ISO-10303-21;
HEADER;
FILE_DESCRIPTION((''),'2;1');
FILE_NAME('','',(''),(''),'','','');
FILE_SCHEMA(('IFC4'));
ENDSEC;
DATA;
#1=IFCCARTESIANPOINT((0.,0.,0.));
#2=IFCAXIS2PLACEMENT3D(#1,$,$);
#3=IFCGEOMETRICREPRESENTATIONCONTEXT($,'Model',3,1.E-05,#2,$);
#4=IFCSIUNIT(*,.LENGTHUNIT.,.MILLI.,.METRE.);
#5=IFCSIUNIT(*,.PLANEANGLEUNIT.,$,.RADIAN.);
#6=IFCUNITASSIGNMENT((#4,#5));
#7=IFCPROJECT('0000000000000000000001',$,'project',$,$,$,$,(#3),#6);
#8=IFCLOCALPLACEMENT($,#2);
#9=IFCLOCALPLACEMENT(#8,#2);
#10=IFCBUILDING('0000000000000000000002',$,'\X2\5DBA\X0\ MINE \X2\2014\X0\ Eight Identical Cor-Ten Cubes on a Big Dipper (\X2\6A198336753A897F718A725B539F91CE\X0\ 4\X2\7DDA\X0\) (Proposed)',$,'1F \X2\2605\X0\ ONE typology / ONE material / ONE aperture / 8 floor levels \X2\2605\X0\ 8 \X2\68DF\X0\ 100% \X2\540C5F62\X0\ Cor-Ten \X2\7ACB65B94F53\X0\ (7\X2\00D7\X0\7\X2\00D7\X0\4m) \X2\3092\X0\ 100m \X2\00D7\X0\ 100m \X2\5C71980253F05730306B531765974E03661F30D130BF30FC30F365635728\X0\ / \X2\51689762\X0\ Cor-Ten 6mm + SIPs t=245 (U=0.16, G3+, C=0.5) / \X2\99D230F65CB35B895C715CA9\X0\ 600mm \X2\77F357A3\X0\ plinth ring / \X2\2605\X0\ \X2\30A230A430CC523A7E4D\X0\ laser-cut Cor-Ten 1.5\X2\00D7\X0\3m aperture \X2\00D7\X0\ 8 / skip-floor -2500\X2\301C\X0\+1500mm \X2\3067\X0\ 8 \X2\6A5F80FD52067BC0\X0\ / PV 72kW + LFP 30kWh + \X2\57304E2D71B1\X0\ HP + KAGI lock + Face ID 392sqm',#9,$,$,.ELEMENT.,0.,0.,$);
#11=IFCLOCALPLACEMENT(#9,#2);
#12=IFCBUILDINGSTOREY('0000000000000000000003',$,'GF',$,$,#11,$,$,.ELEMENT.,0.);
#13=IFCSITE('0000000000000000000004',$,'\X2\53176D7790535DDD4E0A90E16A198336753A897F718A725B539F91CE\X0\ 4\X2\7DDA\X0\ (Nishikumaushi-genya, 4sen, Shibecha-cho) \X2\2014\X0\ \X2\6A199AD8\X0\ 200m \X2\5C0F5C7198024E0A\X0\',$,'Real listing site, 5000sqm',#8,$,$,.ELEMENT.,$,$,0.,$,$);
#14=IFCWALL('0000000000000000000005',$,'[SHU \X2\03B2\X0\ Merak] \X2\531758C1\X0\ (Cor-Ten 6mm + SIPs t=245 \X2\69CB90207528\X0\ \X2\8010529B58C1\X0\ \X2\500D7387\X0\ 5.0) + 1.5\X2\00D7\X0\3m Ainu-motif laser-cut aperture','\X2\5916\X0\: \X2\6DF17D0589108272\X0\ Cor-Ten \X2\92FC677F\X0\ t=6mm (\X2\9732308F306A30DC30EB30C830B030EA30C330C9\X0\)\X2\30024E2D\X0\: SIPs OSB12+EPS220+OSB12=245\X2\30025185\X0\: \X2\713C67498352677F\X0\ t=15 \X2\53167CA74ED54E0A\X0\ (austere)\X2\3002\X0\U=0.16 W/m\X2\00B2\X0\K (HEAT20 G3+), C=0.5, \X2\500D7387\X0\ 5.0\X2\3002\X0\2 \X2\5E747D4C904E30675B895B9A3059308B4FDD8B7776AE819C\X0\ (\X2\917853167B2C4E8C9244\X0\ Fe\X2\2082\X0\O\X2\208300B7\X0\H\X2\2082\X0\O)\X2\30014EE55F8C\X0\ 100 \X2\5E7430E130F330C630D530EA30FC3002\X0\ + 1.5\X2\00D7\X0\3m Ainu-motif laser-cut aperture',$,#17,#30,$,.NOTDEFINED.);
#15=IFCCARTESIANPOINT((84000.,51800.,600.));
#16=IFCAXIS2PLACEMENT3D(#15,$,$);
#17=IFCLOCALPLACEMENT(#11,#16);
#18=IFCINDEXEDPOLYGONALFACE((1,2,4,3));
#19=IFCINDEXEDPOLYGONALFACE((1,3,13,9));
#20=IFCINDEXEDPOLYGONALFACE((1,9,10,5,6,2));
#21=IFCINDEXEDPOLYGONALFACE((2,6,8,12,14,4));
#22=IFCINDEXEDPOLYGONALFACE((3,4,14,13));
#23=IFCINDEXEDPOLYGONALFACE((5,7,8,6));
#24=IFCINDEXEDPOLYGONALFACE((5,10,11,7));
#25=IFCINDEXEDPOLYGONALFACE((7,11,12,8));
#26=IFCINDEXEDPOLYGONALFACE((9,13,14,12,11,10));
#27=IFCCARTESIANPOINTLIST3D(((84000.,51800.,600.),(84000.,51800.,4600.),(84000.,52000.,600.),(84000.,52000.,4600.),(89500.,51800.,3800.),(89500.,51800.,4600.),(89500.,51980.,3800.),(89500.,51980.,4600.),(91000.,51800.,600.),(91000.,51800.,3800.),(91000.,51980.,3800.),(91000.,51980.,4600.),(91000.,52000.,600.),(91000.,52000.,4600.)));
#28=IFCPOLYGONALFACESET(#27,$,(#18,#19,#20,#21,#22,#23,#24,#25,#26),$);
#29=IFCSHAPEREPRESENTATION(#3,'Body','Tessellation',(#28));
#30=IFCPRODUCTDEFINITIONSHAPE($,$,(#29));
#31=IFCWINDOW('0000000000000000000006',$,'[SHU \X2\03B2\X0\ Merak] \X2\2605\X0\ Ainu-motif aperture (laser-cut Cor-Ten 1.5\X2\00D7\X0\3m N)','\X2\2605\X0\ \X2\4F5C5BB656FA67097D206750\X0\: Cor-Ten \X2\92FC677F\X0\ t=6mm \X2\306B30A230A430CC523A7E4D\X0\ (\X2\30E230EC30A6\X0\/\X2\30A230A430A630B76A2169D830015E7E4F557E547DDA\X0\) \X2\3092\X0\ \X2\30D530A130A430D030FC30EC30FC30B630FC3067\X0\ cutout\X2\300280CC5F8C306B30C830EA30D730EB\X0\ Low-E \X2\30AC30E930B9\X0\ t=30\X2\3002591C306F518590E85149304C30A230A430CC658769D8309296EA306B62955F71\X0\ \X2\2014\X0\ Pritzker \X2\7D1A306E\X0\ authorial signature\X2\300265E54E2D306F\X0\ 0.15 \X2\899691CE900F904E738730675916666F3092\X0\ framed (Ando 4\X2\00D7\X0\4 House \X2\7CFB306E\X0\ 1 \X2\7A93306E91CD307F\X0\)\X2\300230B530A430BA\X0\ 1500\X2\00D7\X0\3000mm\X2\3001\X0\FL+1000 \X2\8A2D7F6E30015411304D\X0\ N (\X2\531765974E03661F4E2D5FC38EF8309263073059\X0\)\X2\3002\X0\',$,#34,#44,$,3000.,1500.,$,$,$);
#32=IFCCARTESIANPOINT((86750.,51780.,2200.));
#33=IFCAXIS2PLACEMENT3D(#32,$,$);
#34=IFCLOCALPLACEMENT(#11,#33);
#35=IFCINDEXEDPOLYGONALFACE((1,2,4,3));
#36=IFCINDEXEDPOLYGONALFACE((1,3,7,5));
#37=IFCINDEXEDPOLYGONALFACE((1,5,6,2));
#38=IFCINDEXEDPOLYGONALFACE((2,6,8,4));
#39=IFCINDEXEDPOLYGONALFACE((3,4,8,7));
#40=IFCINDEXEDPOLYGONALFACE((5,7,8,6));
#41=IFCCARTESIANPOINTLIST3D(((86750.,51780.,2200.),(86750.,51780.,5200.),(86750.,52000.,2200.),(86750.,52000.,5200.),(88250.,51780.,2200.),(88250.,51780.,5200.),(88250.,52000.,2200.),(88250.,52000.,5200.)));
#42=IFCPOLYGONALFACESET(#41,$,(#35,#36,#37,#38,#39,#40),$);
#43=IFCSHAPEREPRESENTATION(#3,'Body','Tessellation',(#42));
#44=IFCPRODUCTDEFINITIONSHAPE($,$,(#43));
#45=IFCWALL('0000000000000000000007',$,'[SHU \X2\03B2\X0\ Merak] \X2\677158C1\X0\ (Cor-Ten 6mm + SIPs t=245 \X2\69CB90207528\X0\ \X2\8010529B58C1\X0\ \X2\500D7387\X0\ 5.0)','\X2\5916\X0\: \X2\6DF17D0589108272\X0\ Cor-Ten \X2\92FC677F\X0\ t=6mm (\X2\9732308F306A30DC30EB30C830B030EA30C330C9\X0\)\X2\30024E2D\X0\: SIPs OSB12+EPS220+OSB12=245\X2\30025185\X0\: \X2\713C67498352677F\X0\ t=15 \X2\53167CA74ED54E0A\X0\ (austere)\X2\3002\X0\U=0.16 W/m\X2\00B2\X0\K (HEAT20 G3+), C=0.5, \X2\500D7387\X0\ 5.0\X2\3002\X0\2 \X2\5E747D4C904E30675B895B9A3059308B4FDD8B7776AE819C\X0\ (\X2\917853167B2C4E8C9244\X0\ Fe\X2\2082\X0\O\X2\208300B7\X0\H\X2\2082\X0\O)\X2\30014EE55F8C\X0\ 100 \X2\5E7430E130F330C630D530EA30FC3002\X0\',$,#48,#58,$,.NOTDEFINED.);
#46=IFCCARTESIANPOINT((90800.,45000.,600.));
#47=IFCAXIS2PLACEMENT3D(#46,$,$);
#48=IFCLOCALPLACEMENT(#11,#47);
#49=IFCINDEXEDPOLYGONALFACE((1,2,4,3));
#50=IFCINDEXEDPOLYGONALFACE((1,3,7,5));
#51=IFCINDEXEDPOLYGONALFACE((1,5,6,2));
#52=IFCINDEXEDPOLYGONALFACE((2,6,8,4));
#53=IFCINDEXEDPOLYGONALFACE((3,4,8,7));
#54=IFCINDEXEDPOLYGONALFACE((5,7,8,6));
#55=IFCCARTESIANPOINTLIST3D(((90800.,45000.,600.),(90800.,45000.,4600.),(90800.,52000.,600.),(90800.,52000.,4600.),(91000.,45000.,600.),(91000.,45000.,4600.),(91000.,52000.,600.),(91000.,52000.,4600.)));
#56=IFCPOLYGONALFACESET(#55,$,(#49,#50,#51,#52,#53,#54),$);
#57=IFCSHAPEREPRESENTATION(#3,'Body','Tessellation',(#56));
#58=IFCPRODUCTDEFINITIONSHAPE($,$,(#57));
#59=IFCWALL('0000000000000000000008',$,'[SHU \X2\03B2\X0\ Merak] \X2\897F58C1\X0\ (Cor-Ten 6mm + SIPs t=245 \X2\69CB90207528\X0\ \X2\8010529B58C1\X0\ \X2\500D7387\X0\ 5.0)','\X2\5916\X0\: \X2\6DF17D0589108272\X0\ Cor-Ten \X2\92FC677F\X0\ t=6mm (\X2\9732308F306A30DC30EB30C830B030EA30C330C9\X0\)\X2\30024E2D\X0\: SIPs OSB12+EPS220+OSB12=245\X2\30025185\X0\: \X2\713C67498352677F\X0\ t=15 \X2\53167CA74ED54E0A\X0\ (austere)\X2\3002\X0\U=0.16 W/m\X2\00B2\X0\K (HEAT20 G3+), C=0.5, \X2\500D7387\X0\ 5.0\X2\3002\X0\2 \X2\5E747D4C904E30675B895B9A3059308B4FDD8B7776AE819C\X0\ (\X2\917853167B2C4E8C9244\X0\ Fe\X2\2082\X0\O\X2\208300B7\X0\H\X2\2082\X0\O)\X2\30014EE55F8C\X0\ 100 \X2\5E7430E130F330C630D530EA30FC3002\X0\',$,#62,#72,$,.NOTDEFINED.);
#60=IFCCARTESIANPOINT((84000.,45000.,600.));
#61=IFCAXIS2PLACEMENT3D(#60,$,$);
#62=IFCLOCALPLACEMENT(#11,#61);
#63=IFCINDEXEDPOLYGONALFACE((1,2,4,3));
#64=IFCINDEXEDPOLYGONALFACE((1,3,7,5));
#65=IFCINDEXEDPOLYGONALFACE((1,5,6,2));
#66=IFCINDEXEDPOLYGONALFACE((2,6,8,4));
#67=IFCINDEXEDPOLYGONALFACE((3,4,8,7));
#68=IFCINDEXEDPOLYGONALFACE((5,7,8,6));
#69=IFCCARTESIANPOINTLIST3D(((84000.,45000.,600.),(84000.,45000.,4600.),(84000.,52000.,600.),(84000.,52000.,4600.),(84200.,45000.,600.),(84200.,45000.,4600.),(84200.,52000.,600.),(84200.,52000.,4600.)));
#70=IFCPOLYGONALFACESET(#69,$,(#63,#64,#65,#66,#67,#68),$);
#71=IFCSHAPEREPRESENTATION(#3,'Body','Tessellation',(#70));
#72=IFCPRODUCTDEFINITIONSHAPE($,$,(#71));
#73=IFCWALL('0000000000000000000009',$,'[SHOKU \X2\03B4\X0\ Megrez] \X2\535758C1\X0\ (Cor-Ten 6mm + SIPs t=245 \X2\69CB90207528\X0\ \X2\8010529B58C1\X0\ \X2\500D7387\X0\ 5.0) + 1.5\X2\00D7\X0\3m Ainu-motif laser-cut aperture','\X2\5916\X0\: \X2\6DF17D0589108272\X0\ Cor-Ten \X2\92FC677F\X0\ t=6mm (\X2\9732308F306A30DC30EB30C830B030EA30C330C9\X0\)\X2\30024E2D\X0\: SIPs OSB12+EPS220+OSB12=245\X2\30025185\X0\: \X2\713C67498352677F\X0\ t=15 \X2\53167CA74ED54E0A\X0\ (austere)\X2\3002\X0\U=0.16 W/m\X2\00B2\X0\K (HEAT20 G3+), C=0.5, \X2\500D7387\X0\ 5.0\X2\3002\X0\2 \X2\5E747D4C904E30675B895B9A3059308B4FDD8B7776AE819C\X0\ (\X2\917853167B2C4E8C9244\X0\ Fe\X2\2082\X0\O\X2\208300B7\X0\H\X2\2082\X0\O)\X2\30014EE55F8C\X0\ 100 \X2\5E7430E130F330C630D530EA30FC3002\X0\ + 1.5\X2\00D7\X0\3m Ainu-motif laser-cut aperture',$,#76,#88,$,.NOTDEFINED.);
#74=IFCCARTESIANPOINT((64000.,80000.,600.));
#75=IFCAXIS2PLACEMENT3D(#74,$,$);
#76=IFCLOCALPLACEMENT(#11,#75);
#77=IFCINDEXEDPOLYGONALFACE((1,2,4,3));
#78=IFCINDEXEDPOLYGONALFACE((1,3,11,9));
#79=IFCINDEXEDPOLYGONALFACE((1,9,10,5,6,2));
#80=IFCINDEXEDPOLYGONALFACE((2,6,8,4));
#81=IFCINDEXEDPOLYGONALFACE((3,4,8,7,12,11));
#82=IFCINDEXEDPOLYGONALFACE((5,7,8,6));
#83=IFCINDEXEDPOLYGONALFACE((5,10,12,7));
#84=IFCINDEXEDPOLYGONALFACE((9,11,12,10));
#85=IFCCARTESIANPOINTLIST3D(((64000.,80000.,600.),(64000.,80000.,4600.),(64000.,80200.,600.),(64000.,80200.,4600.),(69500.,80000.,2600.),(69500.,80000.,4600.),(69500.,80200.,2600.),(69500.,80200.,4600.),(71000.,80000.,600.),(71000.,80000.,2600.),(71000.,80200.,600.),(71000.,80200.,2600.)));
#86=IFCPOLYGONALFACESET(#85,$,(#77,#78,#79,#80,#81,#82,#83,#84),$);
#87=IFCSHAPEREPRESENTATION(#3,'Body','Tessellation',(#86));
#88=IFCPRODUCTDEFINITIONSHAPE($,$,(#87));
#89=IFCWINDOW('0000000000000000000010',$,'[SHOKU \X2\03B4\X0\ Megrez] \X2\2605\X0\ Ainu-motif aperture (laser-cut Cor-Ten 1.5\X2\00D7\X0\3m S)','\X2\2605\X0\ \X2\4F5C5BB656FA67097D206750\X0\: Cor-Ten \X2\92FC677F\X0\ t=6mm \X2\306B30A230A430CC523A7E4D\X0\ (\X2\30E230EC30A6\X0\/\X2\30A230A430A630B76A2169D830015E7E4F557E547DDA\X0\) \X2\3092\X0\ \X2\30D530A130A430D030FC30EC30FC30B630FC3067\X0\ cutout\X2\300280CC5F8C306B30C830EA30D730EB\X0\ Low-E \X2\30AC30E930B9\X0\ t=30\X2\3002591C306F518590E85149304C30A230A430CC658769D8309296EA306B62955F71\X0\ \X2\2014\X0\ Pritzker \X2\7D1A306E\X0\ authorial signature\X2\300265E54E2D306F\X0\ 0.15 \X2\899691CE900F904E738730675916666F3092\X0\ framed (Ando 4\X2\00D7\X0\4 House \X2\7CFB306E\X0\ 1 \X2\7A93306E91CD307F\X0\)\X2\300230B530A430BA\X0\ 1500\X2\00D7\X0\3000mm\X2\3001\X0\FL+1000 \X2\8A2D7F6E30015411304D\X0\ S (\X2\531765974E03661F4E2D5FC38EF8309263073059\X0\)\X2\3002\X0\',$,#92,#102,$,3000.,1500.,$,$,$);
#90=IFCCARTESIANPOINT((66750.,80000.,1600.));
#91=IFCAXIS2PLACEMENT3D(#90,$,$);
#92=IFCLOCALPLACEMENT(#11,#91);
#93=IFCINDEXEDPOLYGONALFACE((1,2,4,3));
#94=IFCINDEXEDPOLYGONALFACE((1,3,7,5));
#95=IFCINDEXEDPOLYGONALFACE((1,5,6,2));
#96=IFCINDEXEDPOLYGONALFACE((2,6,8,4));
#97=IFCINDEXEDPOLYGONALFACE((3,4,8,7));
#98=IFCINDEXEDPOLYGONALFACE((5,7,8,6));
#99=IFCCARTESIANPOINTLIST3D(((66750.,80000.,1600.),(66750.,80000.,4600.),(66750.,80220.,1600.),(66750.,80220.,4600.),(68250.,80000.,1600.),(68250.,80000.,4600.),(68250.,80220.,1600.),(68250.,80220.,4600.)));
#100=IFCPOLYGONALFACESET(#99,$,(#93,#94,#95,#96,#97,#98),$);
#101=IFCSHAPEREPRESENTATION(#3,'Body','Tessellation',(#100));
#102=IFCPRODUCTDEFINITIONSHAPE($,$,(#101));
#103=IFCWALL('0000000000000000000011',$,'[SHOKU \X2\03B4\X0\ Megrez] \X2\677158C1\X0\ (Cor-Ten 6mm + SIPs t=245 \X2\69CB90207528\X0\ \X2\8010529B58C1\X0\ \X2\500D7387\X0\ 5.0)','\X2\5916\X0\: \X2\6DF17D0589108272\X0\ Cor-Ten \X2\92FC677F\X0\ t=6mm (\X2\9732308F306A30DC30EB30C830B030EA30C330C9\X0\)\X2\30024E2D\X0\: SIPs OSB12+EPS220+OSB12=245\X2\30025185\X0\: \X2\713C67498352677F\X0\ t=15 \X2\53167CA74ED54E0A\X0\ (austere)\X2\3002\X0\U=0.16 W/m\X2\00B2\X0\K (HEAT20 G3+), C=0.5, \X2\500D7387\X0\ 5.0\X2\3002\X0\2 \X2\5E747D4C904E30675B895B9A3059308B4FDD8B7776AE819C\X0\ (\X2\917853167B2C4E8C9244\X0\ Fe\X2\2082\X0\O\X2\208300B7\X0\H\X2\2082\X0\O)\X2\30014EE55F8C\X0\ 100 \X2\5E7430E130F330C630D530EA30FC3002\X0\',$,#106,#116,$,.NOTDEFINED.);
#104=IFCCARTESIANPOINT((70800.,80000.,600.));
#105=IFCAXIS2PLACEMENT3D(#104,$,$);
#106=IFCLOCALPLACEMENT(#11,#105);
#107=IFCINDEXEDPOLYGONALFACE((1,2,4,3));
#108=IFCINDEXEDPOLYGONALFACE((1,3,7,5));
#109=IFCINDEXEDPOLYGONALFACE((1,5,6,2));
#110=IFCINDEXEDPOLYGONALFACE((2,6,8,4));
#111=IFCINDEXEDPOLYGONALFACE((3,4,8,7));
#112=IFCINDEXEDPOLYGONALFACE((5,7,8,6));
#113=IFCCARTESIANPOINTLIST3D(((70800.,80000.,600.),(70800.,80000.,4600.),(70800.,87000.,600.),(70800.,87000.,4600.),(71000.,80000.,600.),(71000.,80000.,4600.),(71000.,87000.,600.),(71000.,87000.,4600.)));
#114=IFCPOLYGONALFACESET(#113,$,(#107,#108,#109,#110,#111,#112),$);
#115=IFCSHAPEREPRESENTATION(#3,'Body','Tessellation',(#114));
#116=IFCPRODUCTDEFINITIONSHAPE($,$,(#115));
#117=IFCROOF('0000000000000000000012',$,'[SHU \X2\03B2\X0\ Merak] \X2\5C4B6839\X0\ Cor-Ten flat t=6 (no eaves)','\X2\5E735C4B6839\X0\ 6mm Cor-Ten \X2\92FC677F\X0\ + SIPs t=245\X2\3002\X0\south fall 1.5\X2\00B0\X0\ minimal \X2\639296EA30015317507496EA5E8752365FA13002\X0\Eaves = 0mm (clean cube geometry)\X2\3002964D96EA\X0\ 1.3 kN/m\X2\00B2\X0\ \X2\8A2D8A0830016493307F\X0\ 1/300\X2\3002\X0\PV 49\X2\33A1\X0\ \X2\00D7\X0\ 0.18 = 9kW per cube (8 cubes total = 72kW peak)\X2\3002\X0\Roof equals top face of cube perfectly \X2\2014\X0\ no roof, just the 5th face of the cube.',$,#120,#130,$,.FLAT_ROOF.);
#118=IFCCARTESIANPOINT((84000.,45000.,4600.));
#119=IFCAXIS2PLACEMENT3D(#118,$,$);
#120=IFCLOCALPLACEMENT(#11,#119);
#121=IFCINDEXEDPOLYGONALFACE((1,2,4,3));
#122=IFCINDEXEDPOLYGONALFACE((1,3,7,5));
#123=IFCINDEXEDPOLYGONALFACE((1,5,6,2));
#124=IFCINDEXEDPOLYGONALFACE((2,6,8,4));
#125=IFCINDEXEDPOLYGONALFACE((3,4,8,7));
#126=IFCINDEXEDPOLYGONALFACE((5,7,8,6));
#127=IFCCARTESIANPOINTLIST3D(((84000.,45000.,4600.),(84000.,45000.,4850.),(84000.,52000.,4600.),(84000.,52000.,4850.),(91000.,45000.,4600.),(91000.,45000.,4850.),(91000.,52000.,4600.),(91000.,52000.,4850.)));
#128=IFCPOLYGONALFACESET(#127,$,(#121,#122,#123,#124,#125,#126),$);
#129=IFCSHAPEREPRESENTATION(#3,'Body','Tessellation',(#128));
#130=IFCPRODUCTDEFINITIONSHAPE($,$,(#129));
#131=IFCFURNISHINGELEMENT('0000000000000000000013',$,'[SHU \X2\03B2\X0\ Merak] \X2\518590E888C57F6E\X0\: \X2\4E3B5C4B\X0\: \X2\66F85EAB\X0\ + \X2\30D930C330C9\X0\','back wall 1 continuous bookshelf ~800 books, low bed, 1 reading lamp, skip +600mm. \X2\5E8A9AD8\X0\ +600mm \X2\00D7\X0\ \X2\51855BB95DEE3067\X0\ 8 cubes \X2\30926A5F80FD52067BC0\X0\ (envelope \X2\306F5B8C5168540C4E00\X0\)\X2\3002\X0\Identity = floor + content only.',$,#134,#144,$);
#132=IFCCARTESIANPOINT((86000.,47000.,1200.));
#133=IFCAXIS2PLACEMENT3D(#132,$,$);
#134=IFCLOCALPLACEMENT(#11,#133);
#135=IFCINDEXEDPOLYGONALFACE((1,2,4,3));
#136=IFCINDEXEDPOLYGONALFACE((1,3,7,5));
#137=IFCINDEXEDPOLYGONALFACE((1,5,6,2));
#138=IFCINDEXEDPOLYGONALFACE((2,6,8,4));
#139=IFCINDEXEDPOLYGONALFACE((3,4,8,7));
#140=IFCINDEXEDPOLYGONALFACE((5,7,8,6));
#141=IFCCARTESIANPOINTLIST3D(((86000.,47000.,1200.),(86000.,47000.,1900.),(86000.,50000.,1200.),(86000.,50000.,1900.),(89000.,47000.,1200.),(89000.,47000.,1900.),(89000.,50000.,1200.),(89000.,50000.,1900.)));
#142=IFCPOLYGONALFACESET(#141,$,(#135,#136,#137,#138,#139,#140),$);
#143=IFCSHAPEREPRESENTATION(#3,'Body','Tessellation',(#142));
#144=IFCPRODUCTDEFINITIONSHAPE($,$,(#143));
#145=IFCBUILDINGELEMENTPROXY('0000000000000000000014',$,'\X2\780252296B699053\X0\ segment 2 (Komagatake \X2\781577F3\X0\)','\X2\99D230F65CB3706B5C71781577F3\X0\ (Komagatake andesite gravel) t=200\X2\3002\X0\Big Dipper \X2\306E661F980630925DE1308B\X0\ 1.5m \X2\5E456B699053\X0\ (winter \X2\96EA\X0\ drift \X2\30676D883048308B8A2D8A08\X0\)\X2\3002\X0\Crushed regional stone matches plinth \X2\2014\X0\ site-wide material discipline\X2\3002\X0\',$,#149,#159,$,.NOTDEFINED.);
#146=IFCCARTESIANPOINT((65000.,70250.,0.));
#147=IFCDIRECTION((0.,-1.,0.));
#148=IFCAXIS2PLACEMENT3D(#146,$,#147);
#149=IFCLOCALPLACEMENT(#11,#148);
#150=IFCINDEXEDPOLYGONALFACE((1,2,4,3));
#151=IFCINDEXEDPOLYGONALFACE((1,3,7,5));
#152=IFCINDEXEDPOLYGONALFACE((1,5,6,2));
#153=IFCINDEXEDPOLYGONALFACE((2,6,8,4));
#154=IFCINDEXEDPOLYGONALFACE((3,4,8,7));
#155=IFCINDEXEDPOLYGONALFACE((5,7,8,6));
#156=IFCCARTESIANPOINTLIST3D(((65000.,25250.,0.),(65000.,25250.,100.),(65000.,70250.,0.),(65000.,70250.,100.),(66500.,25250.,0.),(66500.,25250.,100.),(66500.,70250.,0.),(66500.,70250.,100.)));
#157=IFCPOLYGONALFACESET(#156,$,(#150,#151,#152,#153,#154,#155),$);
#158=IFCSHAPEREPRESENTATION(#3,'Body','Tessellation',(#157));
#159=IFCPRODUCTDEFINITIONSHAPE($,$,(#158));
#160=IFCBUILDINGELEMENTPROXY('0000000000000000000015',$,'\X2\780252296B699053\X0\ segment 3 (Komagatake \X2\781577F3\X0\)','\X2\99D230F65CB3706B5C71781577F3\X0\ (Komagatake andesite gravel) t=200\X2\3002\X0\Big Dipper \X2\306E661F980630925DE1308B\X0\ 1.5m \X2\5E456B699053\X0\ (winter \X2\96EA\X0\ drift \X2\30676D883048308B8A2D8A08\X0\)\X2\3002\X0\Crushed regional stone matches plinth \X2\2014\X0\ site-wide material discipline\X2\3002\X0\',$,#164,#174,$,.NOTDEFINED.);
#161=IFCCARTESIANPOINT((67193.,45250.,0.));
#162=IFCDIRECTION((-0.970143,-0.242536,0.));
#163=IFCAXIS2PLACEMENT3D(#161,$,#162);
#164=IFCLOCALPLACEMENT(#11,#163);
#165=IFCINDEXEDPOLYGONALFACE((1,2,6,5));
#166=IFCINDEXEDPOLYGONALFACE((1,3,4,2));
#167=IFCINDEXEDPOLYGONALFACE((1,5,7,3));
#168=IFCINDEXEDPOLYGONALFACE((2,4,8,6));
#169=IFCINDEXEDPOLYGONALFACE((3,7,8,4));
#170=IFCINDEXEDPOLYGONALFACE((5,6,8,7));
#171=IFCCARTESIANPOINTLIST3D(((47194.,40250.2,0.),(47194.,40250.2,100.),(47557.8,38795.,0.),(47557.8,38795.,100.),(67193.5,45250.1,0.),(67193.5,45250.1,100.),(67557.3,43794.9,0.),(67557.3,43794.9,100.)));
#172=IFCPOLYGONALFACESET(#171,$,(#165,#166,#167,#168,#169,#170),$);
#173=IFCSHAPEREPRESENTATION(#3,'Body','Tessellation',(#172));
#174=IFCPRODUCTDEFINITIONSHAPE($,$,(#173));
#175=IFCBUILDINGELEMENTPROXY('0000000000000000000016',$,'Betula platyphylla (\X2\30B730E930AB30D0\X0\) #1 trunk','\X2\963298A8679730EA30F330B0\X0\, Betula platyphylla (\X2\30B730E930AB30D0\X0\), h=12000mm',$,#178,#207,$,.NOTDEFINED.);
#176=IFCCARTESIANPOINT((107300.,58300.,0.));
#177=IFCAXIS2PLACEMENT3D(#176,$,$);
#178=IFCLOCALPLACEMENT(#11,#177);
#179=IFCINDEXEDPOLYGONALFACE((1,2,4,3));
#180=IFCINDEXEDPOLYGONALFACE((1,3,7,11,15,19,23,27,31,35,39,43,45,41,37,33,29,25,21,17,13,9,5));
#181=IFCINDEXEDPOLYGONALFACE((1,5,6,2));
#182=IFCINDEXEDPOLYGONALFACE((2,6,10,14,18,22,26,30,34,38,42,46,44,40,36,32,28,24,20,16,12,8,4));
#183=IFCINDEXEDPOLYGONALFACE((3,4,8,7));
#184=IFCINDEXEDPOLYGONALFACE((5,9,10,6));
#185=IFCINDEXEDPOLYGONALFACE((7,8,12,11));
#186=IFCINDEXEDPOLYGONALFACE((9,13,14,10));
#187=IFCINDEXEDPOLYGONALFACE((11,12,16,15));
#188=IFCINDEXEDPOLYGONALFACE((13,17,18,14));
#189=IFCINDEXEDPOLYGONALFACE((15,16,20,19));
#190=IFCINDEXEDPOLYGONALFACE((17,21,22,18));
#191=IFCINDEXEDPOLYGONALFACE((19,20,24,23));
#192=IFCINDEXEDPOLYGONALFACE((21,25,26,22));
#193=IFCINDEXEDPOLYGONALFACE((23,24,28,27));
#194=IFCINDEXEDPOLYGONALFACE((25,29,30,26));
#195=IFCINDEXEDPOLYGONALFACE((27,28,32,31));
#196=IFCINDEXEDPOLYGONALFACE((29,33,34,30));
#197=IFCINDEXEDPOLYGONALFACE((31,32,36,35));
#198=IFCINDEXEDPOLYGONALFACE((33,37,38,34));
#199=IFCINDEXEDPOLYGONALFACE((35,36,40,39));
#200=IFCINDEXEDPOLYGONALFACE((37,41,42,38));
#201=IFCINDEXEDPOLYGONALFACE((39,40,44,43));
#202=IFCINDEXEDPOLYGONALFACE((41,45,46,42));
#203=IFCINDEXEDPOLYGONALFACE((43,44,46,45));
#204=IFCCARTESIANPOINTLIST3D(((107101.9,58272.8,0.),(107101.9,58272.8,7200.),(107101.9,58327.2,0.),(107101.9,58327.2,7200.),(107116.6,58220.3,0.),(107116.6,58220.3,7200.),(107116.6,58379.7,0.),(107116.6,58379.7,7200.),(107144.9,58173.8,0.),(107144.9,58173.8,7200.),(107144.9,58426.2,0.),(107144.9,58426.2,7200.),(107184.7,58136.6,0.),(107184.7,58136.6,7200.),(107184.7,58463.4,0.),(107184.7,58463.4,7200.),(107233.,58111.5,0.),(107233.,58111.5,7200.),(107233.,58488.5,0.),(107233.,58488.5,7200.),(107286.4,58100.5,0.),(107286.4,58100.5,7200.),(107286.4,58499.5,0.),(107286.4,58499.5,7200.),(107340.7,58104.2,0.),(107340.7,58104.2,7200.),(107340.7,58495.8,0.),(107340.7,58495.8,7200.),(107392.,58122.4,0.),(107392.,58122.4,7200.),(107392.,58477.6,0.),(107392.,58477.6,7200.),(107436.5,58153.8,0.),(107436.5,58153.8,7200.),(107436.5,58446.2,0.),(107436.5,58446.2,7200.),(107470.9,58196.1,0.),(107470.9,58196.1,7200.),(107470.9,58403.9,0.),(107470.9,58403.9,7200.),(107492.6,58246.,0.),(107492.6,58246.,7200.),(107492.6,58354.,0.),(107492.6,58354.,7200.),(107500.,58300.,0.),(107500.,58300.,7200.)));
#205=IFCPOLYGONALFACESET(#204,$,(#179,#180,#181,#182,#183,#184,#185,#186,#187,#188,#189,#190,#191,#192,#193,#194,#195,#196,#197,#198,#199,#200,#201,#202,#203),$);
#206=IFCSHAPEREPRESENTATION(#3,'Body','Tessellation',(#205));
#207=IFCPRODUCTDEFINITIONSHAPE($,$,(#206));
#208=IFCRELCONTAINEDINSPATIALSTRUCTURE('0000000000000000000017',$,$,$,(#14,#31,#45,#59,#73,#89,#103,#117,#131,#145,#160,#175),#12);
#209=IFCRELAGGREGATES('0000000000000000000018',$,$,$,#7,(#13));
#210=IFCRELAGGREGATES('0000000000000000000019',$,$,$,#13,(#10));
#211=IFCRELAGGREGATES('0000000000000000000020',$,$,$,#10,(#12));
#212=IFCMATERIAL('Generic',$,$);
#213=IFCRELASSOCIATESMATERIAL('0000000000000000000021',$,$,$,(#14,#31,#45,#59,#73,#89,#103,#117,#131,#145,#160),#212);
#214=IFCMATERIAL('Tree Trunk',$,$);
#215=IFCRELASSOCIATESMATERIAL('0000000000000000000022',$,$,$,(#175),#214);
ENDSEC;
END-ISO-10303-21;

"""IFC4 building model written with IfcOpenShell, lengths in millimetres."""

from ifc_helpers import new_model, si_unit, frame, frame_2d, origin, origin_2d, place, context, project, spatial, rectangle, circle, extrude, material, element, fill, save


model = new_model("IFC4")

# Units and contexts
model_context = context("Model", 3, precision=1e-05, world=origin())
ifc_project = project(units=[si_unit("LENGTHUNIT", "METRE", prefix="MILLI"), si_unit("PLANEANGLEUNIT", "RADIAN")], contexts=[model_context])

# Site, building, storey
site_placement = place(None, origin())
site = spatial("IfcSite", under=ifc_project, at=site_placement, Name="北海道川上郡標茶町西熊牛原野 4線 (Nishikumaushi-genya, 4sen, Shibecha-cho) — 標高 200m 小山頂上", ObjectType="Real listing site, 5000sqm", CompositionType="ELEMENT", RefElevation=0.0)
building_placement = place(site_placement, origin())
building = spatial("IfcBuilding", under=site, at=building_placement, Name="嶺 MINE — Eight Identical Cor-Ten Cubes on a Big Dipper (標茶町西熊牛原野 4線) (Proposed)", ObjectType="1F ★ ONE typology / ONE material / ONE aperture / 8 floor levels ★ 8 棟 100% 同形 Cor-Ten 立方体 (7×7×4m) を 100m × 100m 山頂台地に北斗七星パターン散在 / 全面 Cor-Ten 6mm + SIPs t=245 (U=0.16, G3+, C=0.5) / 駒ヶ岳安山岩 600mm 石垣 plinth ring / ★ アイヌ刺繍 laser-cut Cor-Ten 1.5×3m aperture × 8 / skip-floor -2500〜+1500mm で 8 機能分節 / PV 72kW + LFP 30kWh + 地中熱 HP + KAGI lock + Face ID 392sqm", CompositionType="ELEMENT", ElevationOfRefHeight=0.0, ElevationOfTerrain=0.0)
storey_placement = place(building_placement, origin())
storey = spatial("IfcBuildingStorey", under=building, at=storey_placement, Name="GF", CompositionType="ELEMENT", Elevation=0.0)

# Wall, opening, window
ifc_material_1 = material(Name="Generic")
wall_1_placement = place(storey_placement, frame((84000.0, 51800.0, 600.0)))
wall_1 = element("IfcWall", 1, at=wall_1_placement, inside=storey, material=ifc_material_1, Name="[SHU β Merak] 北壁 (Cor-Ten 6mm + SIPs t=245 構造用 耐力壁 倍率 5.0) + 1.5×3m Ainu-motif laser-cut aperture", Description="外: 深紅褐色 Cor-Ten 鋼板 t=6mm (露わなボルトグリッド)。中: SIPs OSB12+EPS220+OSB12=245。内: 焼杉荒板 t=15 化粧仕上 (austere)。U=0.16 W/m²K (HEAT20 G3+), C=0.5, 倍率 5.0。2 年経過で安定する保護皮膜 (酸化第二鉄 Fe₂O₃·H₂O)、以後 100 年メンテフリー。 + 1.5×3m Ainu-motif laser-cut aperture", PredefinedType="NOTDEFINED", context=model_context, shape_type="SweptSolid", body=[
    extrude(rectangle(XDim=7000.0, YDim=200.0, at=frame_2d((3500.0, 100.0))), frame((84000.0, 51800.0, 600.0)), (0.0, 0.0, 1.0), 4000.0),
])
opening_1_placement = place(storey_placement, frame((86750.0, 51780.0, 2200.0)))
opening_1 = element("IfcOpeningElement", 2, at=opening_1_placement, cuts=wall_1, PredefinedType="NOTDEFINED", context=model_context, shape_type="SweptSolid", body=[
    extrude(rectangle(XDim=1500.0, YDim=220.0, at=frame_2d((750.0, 110.0))), frame((86750.0, 51780.0, 2200.0)), (0.0, 0.0, 1.0), 3000.0),
])
window_1_placement = place(storey_placement, frame((86750.0, 51780.0, 2200.0)))
window_1 = element("IfcWindow", 3, at=window_1_placement, inside=storey, material=ifc_material_1, Name="[SHU β Merak] ★ Ainu-motif aperture (laser-cut Cor-Ten 1.5×3m N)", Description="★ 作家固有素材: Cor-Ten 鋼板 t=6mm にアイヌ刺繍 (モレウ/アイウシ模様、幾何織線) を ファイバーレーザーで cutout。背後にトリプル Low-E ガラス t=30。夜は内部光がアイヌ文様を雪に投影 — Pritzker 級の authorial signature。日中は 0.15 視野透過率で外景を framed (Ando 4×4 House 系の 1 窓の重み)。サイズ 1500×3000mm、FL+1000 設置、向き N (北斗七星中心軸を指す)。", OverallHeight=3000.0, OverallWidth=1500.0, context=model_context, shape_type="SweptSolid", body=[
    extrude(rectangle(XDim=1500.0, YDim=220.0, at=frame_2d((750.0, 110.0))), frame((86750.0, 51780.0, 2200.0)), (0.0, 0.0, 1.0), 3000.0),
])
fill(opening_1, window_1)

# Walls
wall_2_placement = place(storey_placement, frame((90800.0, 45000.0, 600.0)))
element("IfcWall", 4, at=wall_2_placement, inside=storey, material=ifc_material_1, Name="[SHU β Merak] 東壁 (Cor-Ten 6mm + SIPs t=245 構造用 耐力壁 倍率 5.0)", Description="外: 深紅褐色 Cor-Ten 鋼板 t=6mm (露わなボルトグリッド)。中: SIPs OSB12+EPS220+OSB12=245。内: 焼杉荒板 t=15 化粧仕上 (austere)。U=0.16 W/m²K (HEAT20 G3+), C=0.5, 倍率 5.0。2 年経過で安定する保護皮膜 (酸化第二鉄 Fe₂O₃·H₂O)、以後 100 年メンテフリー。", PredefinedType="NOTDEFINED", context=model_context, shape_type="SweptSolid", body=[
    extrude(rectangle(XDim=200.0, YDim=7000.0, at=frame_2d((100.0, 3500.0))), frame((90800.0, 45000.0, 600.0)), (0.0, 0.0, 1.0), 4000.0),
])
wall_3_placement = place(storey_placement, frame((84000.0, 45000.0, 600.0)))
element("IfcWall", 5, at=wall_3_placement, inside=storey, material=ifc_material_1, Name="[SHU β Merak] 西壁 (Cor-Ten 6mm + SIPs t=245 構造用 耐力壁 倍率 5.0)", Description="外: 深紅褐色 Cor-Ten 鋼板 t=6mm (露わなボルトグリッド)。中: SIPs OSB12+EPS220+OSB12=245。内: 焼杉荒板 t=15 化粧仕上 (austere)。U=0.16 W/m²K (HEAT20 G3+), C=0.5, 倍率 5.0。2 年経過で安定する保護皮膜 (酸化第二鉄 Fe₂O₃·H₂O)、以後 100 年メンテフリー。", PredefinedType="NOTDEFINED", context=model_context, shape_type="SweptSolid", body=[
    extrude(rectangle(XDim=200.0, YDim=7000.0, at=frame_2d((100.0, 3500.0))), frame((84000.0, 45000.0, 600.0)), (0.0, 0.0, 1.0), 4000.0),
])

# Wall, opening, window
wall_4_placement = place(storey_placement, frame((64000.0, 80000.0, 600.0)))
wall_4 = element("IfcWall", 6, at=wall_4_placement, inside=storey, material=ifc_material_1, Name="[SHOKU δ Megrez] 南壁 (Cor-Ten 6mm + SIPs t=245 構造用 耐力壁 倍率 5.0) + 1.5×3m Ainu-motif laser-cut aperture", Description="外: 深紅褐色 Cor-Ten 鋼板 t=6mm (露わなボルトグリッド)。中: SIPs OSB12+EPS220+OSB12=245。内: 焼杉荒板 t=15 化粧仕上 (austere)。U=0.16 W/m²K (HEAT20 G3+), C=0.5, 倍率 5.0。2 年経過で安定する保護皮膜 (酸化第二鉄 Fe₂O₃·H₂O)、以後 100 年メンテフリー。 + 1.5×3m Ainu-motif laser-cut aperture", PredefinedType="NOTDEFINED", context=model_context, shape_type="SweptSolid", body=[
    extrude(rectangle(XDim=7000.0, YDim=200.0, at=frame_2d((3500.0, 100.0))), frame((64000.0, 80000.0, 600.0)), (0.0, 0.0, 1.0), 4000.0),
])
opening_2_placement = place(storey_placement, frame((66750.0, 80000.0, 1600.0)))
opening_2 = element("IfcOpeningElement", 7, at=opening_2_placement, cuts=wall_4, PredefinedType="NOTDEFINED", context=model_context, shape_type="SweptSolid", body=[
    extrude(rectangle(XDim=1500.0, YDim=220.0, at=frame_2d((750.0, 110.0))), frame((66750.0, 80000.0, 1600.0)), (0.0, 0.0, 1.0), 3000.0),
])
window_2_placement = place(storey_placement, frame((66750.0, 80000.0, 1600.0)))
window_2 = element("IfcWindow", 8, at=window_2_placement, inside=storey, material=ifc_material_1, Name="[SHOKU δ Megrez] ★ Ainu-motif aperture (laser-cut Cor-Ten 1.5×3m S)", Description="★ 作家固有素材: Cor-Ten 鋼板 t=6mm にアイヌ刺繍 (モレウ/アイウシ模様、幾何織線) を ファイバーレーザーで cutout。背後にトリプル Low-E ガラス t=30。夜は内部光がアイヌ文様を雪に投影 — Pritzker 級の authorial signature。日中は 0.15 視野透過率で外景を framed (Ando 4×4 House 系の 1 窓の重み)。サイズ 1500×3000mm、FL+1000 設置、向き S (北斗七星中心軸を指す)。", OverallHeight=3000.0, OverallWidth=1500.0, context=model_context, shape_type="SweptSolid", body=[
    extrude(rectangle(XDim=1500.0, YDim=220.0, at=frame_2d((750.0, 110.0))), frame((66750.0, 80000.0, 1600.0)), (0.0, 0.0, 1.0), 3000.0),
])
fill(opening_2, window_2)

# Wall
wall_5_placement = place(storey_placement, frame((70800.0, 80000.0, 600.0)))
element("IfcWall", 9, at=wall_5_placement, inside=storey, material=ifc_material_1, Name="[SHOKU δ Megrez] 東壁 (Cor-Ten 6mm + SIPs t=245 構造用 耐力壁 倍率 5.0)", Description="外: 深紅褐色 Cor-Ten 鋼板 t=6mm (露わなボルトグリッド)。中: SIPs OSB12+EPS220+OSB12=245。内: 焼杉荒板 t=15 化粧仕上 (austere)。U=0.16 W/m²K (HEAT20 G3+), C=0.5, 倍率 5.0。2 年経過で安定する保護皮膜 (酸化第二鉄 Fe₂O₃·H₂O)、以後 100 年メンテフリー。", PredefinedType="NOTDEFINED", context=model_context, shape_type="SweptSolid", body=[
    extrude(rectangle(XDim=200.0, YDim=7000.0, at=frame_2d((100.0, 3500.0))), frame((70800.0, 80000.0, 600.0)), (0.0, 0.0, 1.0), 4000.0),
])

# Roof
roof_placement = place(storey_placement, frame((84000.0, 45000.0, 4600.0)))
element("IfcRoof", 10, at=roof_placement, inside=storey, material=ifc_material_1, Name="[SHU β Merak] 屋根 Cor-Ten flat t=6 (no eaves)", Description="平屋根 6mm Cor-Ten 鋼板 + SIPs t=245。south fall 1.5° minimal 排雪、北側雪庇制御。Eaves = 0mm (clean cube geometry)。降雪 1.3 kN/m² 設計、撓み 1/300。PV 49㎡ × 0.18 = 9kW per cube (8 cubes total = 72kW peak)。Roof equals top face of cube perfectly — no roof, just the 5th face of the cube.", PredefinedType="FLAT_ROOF", context=model_context, shape_type="SweptSolid", body=[
    extrude(rectangle(XDim=7000.0, YDim=7000.0, at=frame_2d((3500.0, 3500.0))), frame((84000.0, 45000.0, 4600.0)), (0.0, 0.0, 1.0), 250.0),
])

# Furnishing element
furnishing_placement = place(storey_placement, frame((86000.0, 47000.0, 1200.0)))
element("IfcFurnishingElement", 11, at=furnishing_placement, inside=storey, material=ifc_material_1, Name="[SHU β Merak] 内部装置: 主屋: 書庫 + ベッド", Description="back wall 1 continuous bookshelf ~800 books, low bed, 1 reading lamp, skip +600mm. 床高 +600mm × 内容差で 8 cubes を機能分節 (envelope は完全同一)。Identity = floor + content only.", context=model_context, shape_type="SweptSolid", body=[
    extrude(rectangle(XDim=3000.0, YDim=3000.0, at=frame_2d((1500.0, 1500.0))), frame((86000.0, 47000.0, 1200.0)), (0.0, 0.0, 1.0), 700.0),
])

# Building element proxies
proxy_1_placement = place(storey_placement, frame((65000.0, 70250.0, 0.0), x_axis=(0.0, -1.0, 0.0)))
element("IfcBuildingElementProxy", 12, at=proxy_1_placement, inside=storey, material=ifc_material_1, Name="砂利歩道 segment 2 (Komagatake 砕石)", Description="駒ヶ岳火山砕石 (Komagatake andesite gravel) t=200。Big Dipper の星順を巡る 1.5m 幅歩道 (winter 雪 drift で消える設計)。Crushed regional stone matches plinth — site-wide material discipline。", PredefinedType="NOTDEFINED", context=model_context, shape_type="SweptSolid", body=[
    extrude(rectangle(XDim=45000.0, YDim=1500.0, at=frame_2d((22500.0, 750.0))), frame((65000.0, 70250.0, 0.0), x_axis=(0.0, -1.0, 0.0)), (0.0, 0.0, 1.0), 100.0),
])
proxy_2_placement = place(storey_placement, frame((67193.0, 45250.0, 0.0), x_axis=(-0.970143, -0.242536, 0.0)))
element("IfcBuildingElementProxy", 13, at=proxy_2_placement, inside=storey, material=ifc_material_1, Name="砂利歩道 segment 3 (Komagatake 砕石)", Description="駒ヶ岳火山砕石 (Komagatake andesite gravel) t=200。Big Dipper の星順を巡る 1.5m 幅歩道 (winter 雪 drift で消える設計)。Crushed regional stone matches plinth — site-wide material discipline。", PredefinedType="NOTDEFINED", context=model_context, shape_type="SweptSolid", body=[
    extrude(rectangle(XDim=20615.0, YDim=1500.0, at=frame_2d((10307.0, 750.0))), frame((67193.0, 45250.0, 0.0), x_axis=(-0.970143, -0.242536, 0.0)), (0.0, 0.0, 1.0), 100.0),
])
ifc_material_2 = material(Name="Tree Trunk")
proxy_3_placement = place(storey_placement, frame((107300.0, 58300.0, 0.0)))
element("IfcBuildingElementProxy", 14, at=proxy_3_placement, inside=storey, material=ifc_material_2, Name="Betula platyphylla (シラカバ) #1 trunk", Description="防風林リング, Betula platyphylla (シラカバ), h=12000mm", PredefinedType="NOTDEFINED", context=model_context, shape_type="SweptSolid", body=[
    extrude(circle(Radius=200.0, at=origin_2d()), frame((107300.0, 58300.0, 0.0)), (0.0, 0.0, 1.0), 7200.0),
])

save(model, "model.ifc")
